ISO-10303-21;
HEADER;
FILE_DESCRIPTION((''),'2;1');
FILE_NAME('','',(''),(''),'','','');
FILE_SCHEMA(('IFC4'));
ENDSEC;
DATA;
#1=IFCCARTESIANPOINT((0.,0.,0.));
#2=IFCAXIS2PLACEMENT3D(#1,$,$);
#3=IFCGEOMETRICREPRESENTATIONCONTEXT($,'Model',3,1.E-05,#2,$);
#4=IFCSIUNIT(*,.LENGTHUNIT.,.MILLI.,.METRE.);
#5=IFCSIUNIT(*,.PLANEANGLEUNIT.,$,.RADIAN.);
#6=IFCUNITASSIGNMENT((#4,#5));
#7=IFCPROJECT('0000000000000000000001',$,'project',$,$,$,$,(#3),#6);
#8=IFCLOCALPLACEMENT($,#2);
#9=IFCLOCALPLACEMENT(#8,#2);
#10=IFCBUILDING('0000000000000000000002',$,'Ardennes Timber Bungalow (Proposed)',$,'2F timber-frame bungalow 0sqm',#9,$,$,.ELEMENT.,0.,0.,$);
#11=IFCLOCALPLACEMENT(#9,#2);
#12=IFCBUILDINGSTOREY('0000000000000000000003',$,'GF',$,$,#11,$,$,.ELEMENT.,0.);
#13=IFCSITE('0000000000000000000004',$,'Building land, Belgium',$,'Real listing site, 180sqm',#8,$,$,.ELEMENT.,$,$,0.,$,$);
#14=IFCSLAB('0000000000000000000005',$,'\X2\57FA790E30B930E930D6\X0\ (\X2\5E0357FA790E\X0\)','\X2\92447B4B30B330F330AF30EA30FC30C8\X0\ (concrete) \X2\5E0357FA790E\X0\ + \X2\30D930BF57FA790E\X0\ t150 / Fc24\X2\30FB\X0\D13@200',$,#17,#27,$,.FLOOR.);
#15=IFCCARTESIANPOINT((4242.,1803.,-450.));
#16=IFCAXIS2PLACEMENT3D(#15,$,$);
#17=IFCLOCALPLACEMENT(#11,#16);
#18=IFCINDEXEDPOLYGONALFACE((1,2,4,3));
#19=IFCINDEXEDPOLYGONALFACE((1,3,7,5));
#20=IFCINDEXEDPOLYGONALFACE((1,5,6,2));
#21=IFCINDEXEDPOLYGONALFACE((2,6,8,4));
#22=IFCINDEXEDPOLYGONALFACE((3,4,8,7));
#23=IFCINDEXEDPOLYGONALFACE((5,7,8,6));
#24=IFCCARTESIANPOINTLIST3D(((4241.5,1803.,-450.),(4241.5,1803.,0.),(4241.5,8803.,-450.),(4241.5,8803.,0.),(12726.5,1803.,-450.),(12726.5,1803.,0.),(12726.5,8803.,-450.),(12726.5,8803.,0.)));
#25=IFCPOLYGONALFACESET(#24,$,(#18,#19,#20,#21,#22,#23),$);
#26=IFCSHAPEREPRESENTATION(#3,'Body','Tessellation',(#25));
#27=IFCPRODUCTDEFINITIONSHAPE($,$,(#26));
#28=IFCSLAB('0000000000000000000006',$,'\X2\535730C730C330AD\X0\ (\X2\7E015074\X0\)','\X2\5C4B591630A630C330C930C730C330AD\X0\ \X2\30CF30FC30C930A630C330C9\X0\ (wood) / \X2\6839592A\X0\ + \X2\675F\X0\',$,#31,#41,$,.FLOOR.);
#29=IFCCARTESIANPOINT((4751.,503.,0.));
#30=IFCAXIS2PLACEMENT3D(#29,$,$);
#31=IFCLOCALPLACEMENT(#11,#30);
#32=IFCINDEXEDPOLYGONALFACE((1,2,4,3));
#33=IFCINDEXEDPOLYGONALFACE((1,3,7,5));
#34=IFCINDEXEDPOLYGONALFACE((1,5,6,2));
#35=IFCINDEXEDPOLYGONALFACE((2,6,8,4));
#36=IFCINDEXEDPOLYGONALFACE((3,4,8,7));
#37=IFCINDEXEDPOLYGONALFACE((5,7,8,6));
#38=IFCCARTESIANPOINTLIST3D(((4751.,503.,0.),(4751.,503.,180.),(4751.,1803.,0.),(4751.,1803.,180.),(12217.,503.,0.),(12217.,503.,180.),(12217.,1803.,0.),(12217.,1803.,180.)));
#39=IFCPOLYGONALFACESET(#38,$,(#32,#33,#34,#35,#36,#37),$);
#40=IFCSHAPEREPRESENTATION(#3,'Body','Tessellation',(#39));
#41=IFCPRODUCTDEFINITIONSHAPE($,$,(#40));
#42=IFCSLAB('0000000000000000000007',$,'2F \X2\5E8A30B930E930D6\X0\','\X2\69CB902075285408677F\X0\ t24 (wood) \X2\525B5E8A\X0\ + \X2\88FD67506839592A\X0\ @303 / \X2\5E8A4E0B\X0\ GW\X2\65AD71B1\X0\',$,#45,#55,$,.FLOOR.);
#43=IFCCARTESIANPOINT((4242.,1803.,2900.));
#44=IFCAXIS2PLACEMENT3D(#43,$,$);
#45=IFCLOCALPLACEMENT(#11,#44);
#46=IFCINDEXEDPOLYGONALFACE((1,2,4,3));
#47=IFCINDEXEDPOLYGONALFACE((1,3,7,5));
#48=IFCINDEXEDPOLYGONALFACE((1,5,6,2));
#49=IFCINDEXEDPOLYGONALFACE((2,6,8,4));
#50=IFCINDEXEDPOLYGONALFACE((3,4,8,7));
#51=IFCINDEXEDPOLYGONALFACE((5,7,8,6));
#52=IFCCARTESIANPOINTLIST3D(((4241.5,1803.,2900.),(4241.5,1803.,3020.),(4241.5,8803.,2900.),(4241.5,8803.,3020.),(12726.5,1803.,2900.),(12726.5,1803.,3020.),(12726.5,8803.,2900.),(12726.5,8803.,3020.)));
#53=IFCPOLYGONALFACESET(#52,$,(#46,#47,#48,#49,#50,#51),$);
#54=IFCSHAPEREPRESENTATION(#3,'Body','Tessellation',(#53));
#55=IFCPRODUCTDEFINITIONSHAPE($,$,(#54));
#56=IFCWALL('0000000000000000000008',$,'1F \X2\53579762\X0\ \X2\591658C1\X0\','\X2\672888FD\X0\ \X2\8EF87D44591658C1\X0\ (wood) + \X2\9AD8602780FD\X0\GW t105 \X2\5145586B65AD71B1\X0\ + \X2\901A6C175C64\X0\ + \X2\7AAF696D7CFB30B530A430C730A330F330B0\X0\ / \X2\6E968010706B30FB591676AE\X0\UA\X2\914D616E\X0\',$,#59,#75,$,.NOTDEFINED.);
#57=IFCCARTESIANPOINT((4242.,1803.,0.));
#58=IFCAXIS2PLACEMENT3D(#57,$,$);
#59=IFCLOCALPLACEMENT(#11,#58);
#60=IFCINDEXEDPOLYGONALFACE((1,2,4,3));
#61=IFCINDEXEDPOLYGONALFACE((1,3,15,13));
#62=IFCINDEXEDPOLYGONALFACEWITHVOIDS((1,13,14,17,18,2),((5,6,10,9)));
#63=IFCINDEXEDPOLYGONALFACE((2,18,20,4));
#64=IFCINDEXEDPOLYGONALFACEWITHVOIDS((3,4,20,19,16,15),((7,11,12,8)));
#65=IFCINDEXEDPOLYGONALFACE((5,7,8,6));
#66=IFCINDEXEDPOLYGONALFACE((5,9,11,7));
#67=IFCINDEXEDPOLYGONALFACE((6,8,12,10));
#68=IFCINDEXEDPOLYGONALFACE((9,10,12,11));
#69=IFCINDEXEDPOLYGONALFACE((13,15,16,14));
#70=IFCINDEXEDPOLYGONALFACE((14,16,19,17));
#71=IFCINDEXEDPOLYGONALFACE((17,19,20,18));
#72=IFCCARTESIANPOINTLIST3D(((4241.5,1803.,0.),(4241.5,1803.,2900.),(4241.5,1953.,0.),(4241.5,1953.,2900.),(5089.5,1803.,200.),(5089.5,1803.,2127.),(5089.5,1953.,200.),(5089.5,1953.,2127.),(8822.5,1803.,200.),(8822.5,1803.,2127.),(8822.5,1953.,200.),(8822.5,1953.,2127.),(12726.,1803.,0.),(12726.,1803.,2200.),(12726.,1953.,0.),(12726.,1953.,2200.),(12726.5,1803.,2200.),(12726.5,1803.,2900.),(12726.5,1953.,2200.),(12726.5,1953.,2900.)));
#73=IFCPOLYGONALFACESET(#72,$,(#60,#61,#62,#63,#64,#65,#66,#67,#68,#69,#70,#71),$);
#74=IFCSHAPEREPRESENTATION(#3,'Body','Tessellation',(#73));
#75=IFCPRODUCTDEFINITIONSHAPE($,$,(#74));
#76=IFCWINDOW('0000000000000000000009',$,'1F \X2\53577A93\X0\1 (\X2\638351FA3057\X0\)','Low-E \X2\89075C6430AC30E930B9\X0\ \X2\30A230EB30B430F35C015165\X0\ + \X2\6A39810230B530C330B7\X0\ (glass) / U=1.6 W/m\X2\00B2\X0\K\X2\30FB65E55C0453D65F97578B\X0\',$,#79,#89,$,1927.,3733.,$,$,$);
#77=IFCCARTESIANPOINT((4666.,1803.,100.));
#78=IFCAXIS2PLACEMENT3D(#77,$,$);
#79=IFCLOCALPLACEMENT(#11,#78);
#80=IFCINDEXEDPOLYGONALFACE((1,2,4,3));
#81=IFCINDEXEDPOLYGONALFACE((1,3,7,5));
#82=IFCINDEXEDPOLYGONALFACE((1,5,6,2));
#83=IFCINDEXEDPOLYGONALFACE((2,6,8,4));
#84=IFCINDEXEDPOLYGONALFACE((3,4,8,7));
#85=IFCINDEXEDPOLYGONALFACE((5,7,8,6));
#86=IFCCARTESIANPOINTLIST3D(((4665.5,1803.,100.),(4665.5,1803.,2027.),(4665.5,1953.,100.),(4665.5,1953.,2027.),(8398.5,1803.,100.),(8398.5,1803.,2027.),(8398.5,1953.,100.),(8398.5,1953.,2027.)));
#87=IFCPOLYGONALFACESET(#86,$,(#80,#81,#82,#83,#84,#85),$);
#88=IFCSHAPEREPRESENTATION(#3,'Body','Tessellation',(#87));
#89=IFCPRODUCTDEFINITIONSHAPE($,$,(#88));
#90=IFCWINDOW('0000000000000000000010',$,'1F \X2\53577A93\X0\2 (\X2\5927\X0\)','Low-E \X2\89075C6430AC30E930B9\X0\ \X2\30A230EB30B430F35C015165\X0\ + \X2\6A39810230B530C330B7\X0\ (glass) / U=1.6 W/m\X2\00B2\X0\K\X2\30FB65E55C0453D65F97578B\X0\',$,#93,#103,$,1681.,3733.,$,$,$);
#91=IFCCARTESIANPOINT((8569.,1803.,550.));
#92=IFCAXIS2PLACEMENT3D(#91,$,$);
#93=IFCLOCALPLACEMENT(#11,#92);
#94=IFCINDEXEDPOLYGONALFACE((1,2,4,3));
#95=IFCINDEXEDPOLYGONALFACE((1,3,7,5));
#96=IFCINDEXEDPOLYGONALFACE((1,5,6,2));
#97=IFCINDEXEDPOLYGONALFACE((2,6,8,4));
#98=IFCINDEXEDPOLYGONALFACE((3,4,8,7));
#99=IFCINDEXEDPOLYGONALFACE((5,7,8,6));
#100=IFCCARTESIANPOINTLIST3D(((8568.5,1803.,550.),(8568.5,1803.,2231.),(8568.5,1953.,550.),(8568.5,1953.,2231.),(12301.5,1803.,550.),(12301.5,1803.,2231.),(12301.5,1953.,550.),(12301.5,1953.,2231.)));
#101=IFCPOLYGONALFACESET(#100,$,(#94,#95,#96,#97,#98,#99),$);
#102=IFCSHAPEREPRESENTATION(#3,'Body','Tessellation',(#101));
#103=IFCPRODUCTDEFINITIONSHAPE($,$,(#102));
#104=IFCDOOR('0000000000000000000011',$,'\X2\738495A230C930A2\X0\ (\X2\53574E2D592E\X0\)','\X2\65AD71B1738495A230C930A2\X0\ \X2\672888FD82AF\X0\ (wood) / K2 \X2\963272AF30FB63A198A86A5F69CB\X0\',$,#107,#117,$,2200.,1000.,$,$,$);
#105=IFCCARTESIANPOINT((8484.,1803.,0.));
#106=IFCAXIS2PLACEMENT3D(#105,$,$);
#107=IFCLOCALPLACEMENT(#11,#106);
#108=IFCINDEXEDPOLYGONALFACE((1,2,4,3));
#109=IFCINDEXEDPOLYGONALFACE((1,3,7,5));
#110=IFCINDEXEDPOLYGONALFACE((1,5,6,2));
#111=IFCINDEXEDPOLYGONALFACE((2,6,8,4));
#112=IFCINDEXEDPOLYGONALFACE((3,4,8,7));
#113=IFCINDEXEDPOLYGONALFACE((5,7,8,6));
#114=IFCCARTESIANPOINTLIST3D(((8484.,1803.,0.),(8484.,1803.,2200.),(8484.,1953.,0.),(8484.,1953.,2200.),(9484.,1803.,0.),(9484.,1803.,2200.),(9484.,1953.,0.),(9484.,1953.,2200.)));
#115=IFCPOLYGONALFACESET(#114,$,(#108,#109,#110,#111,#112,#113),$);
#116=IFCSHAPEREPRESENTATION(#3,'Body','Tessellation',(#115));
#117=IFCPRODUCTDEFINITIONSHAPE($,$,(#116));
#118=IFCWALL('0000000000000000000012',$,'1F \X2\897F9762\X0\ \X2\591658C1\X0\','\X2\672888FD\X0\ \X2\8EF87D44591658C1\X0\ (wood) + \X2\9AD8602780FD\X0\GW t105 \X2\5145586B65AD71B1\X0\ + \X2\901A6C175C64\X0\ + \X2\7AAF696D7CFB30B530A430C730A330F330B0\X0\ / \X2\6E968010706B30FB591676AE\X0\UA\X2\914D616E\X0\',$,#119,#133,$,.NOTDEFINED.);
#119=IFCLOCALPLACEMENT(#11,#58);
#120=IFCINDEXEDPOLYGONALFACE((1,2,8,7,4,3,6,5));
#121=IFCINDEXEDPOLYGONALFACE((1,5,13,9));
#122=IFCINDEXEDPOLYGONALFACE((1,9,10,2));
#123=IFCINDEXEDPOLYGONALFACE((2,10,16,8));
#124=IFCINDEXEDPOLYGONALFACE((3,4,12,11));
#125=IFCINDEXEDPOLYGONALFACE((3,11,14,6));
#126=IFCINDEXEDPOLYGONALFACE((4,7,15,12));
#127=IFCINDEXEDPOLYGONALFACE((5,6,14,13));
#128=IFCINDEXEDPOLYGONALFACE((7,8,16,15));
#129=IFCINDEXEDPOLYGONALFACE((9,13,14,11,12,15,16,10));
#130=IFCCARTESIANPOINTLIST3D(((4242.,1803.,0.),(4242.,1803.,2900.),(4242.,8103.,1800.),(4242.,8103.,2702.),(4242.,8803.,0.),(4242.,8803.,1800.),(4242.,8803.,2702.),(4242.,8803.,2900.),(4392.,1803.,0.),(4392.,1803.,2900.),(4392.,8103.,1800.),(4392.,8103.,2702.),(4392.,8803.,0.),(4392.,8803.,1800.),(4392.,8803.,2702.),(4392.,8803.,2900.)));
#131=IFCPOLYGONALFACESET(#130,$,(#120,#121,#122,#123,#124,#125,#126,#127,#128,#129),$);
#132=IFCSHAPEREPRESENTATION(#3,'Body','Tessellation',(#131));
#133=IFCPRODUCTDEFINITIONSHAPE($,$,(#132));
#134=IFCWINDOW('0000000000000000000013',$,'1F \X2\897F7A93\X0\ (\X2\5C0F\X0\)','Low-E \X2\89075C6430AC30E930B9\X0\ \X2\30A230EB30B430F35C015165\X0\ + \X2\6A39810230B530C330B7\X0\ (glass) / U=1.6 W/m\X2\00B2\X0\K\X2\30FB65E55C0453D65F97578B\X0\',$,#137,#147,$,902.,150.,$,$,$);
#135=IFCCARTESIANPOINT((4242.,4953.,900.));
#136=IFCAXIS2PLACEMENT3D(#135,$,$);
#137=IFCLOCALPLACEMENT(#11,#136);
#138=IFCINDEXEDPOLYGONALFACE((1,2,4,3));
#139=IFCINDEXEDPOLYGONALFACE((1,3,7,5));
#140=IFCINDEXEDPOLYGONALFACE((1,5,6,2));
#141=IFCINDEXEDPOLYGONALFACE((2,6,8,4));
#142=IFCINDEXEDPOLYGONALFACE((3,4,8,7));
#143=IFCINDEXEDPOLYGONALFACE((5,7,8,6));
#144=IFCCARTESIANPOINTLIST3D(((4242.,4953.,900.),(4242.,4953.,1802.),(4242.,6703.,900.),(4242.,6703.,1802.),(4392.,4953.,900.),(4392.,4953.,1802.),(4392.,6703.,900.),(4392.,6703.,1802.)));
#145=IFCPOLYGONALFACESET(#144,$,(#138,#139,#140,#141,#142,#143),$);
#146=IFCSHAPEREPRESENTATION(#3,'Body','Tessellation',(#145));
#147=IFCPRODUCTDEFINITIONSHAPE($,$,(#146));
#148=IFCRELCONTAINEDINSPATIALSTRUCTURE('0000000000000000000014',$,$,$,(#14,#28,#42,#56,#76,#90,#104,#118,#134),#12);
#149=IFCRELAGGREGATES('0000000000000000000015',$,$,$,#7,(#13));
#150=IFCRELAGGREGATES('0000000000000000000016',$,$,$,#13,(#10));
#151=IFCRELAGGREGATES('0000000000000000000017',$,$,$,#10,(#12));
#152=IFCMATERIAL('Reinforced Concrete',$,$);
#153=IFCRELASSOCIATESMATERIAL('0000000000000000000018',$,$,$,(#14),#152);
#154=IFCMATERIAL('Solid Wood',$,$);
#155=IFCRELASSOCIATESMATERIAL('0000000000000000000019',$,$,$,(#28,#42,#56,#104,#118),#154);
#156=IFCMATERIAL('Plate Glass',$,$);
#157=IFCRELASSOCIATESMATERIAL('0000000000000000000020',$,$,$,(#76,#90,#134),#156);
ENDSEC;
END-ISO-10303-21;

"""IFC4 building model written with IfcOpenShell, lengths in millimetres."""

from ifc_helpers import new_model, si_unit, frame, frame_2d, origin, place, context, project, spatial, rectangle, extrude, material, element, fill, save


model = new_model("IFC4")

# Units and contexts
model_context = context("Model", 3, precision=1e-05, world=origin())
ifc_project = project(units=[si_unit("LENGTHUNIT", "METRE", prefix="MILLI"), si_unit("PLANEANGLEUNIT", "RADIAN")], contexts=[model_context])

# Site, building, storey
site_placement = place(None, origin())
site = spatial("IfcSite", under=ifc_project, at=site_placement, Name="Building land, Belgium", ObjectType="Real listing site, 180sqm", CompositionType="ELEMENT", RefElevation=0.0)
building_placement = place(site_placement, origin())
building = spatial("IfcBuilding", under=site, at=building_placement, Name="Ardennes Timber Bungalow (Proposed)", ObjectType="2F timber-frame bungalow 0sqm", CompositionType="ELEMENT", ElevationOfRefHeight=0.0, ElevationOfTerrain=0.0)
storey_placement = place(building_placement, origin())
storey = spatial("IfcBuildingStorey", under=building, at=storey_placement, Name="GF", CompositionType="ELEMENT", Elevation=0.0)

# Slabs
ifc_material_1 = material(Name="Reinforced Concrete")
slab_1_placement = place(storey_placement, frame((4242.0, 1803.0, -450.0)))
element("IfcSlab", 1, at=slab_1_placement, inside=storey, material=ifc_material_1, Name="基礎スラブ (布基礎)", Description="鉄筋コンクリート (concrete) 布基礎 + ベタ基礎 t150 / Fc24・D13@200", PredefinedType="FLOOR", context=model_context, shape_type="SweptSolid", body=[
    extrude(rectangle(XDim=8485.0, YDim=7000.0, at=frame_2d((4242.0, 3500.0))), frame((4242.0, 1803.0, -450.0)), (0.0, 0.0, 1.0), 450.0),
])
ifc_material_2 = material(Name="Solid Wood")
slab_2_placement = place(storey_placement, frame((4751.0, 503.0, 0.0)))
element("IfcSlab", 2, at=slab_2_placement, inside=storey, material=ifc_material_2, Name="南デッキ (縁側)", Description="屋外ウッドデッキ ハードウッド (wood) / 根太 + 束", PredefinedType="FLOOR", context=model_context, shape_type="SweptSolid", body=[
    extrude(rectangle(XDim=7466.0, YDim=1300.0, at=frame_2d((3733.0, 650.0))), frame((4751.0, 503.0, 0.0)), (0.0, 0.0, 1.0), 180.0),
])
slab_3_placement = place(storey_placement, frame((4242.0, 1803.0, 2900.0)))
element("IfcSlab", 3, at=slab_3_placement, inside=storey, material=ifc_material_2, Name="2F 床スラブ", Description="構造用合板 t24 (wood) 剛床 + 製材根太 @303 / 床下 GW断熱", PredefinedType="FLOOR", context=model_context, shape_type="SweptSolid", body=[
    extrude(rectangle(XDim=8485.0, YDim=7000.0, at=frame_2d((4242.0, 3500.0))), frame((4242.0, 1803.0, 2900.0)), (0.0, 0.0, 1.0), 120.0),
])

# Wall, openings, windows, door
wall_1_placement = place(storey_placement, frame((4242.0, 1803.0, 0.0)))
wall_1 = element("IfcWall", 4, at=wall_1_placement, inside=storey, material=ifc_material_2, Name="1F 南面 外壁", Description="木製 軸組外壁 (wood) + 高性能GW t105 充填断熱 + 通気層 + 窯業系サイディング / 準耐火・外皮UA配慮", PredefinedType="NOTDEFINED", context=model_context, shape_type="SweptSolid", body=[
    extrude(rectangle(XDim=8485.0, YDim=150.0, at=frame_2d((4242.0, 75.0))), frame((4242.0, 1803.0, 0.0)), (0.0, 0.0, 1.0), 2900.0),
])
opening_1_placement = place(storey_placement, frame((4666.0, 1803.0, 100.0)))
opening_1 = element("IfcOpeningElement", 5, at=opening_1_placement, cuts=wall_1, PredefinedType="NOTDEFINED", context=model_context, shape_type="SweptSolid", body=[
    extrude(rectangle(XDim=3733.0, YDim=150.0, at=frame_2d((1866.0, 75.0))), frame((4666.0, 1803.0, 100.0)), (0.0, 0.0, 1.0), 1927.0),
])
opening_2_placement = place(storey_placement, frame((8569.0, 1803.0, 550.0)))
opening_2 = element("IfcOpeningElement", 6, at=opening_2_placement, cuts=wall_1, PredefinedType="NOTDEFINED", context=model_context, shape_type="SweptSolid", body=[
    extrude(rectangle(XDim=3733.0, YDim=150.0, at=frame_2d((1866.0, 75.0))), frame((8569.0, 1803.0, 550.0)), (0.0, 0.0, 1.0), 1681.0),
])
opening_3_placement = place(storey_placement, frame((8484.0, 1803.0, 0.0)))
opening_3 = element("IfcOpeningElement", 7, at=opening_3_placement, cuts=wall_1, PredefinedType="NOTDEFINED", context=model_context, shape_type="SweptSolid", body=[
    extrude(rectangle(XDim=1000.0, YDim=150.0, at=frame_2d((500.0, 75.0))), frame((8484.0, 1803.0, 0.0)), (0.0, 0.0, 1.0), 2200.0),
])
ifc_material_3 = material(Name="Plate Glass")
window_1_placement = place(storey_placement, frame((4666.0, 1803.0, 100.0)))
window_1 = element("IfcWindow", 8, at=window_1_placement, inside=storey, material=ifc_material_3, Name="1F 南窓1 (掃出し)", Description="Low-E 複層ガラス アルゴン封入 + 樹脂サッシ (glass) / U=1.6 W/m²K・日射取得型", OverallHeight=1927.0, OverallWidth=3733.0, context=model_context, shape_type="SweptSolid", body=[
    extrude(rectangle(XDim=3733.0, YDim=150.0, at=frame_2d((1866.0, 75.0))), frame((4666.0, 1803.0, 100.0)), (0.0, 0.0, 1.0), 1927.0),
])
fill(opening_1, window_1)
window_2_placement = place(storey_placement, frame((8569.0, 1803.0, 550.0)))
window_2 = element("IfcWindow", 9, at=window_2_placement, inside=storey, material=ifc_material_3, Name="1F 南窓2 (大)", Description="Low-E 複層ガラス アルゴン封入 + 樹脂サッシ (glass) / U=1.6 W/m²K・日射取得型", OverallHeight=1681.0, OverallWidth=3733.0, context=model_context, shape_type="SweptSolid", body=[
    extrude(rectangle(XDim=3733.0, YDim=150.0, at=frame_2d((1866.0, 75.0))), frame((8569.0, 1803.0, 550.0)), (0.0, 0.0, 1.0), 1681.0),
])
fill(opening_2, window_2)
door_placement = place(storey_placement, frame((8484.0, 1803.0, 0.0)))
door = element("IfcDoor", 10, at=door_placement, inside=storey, material=ifc_material_2, Name="玄関ドア (南中央)", Description="断熱玄関ドア 木製芯 (wood) / K2 防犯・採風機構", OverallHeight=2200.0, OverallWidth=1000.0, context=model_context, shape_type="SweptSolid", body=[
    extrude(rectangle(XDim=1000.0, YDim=150.0, at=frame_2d((500.0, 75.0))), frame((8484.0, 1803.0, 0.0)), (0.0, 0.0, 1.0), 2200.0),
])
fill(opening_3, door)

# Wall, opening, window
wall_2_placement = place(storey_placement, frame((4242.0, 1803.0, 0.0)))
wall_2 = element("IfcWall", 11, at=wall_2_placement, inside=storey, material=ifc_material_2, Name="1F 西面 外壁", Description="木製 軸組外壁 (wood) + 高性能GW t105 充填断熱 + 通気層 + 窯業系サイディング / 準耐火・外皮UA配慮", PredefinedType="NOTDEFINED", context=model_context, shape_type="SweptSolid", body=[
    extrude(rectangle(XDim=150.0, YDim=7000.0, at=frame_2d((75.0, 3500.0))), frame((4242.0, 1803.0, 0.0)), (0.0, 0.0, 1.0), 2900.0),
])
opening_4_placement = place(storey_placement, frame((4242.0, 4953.0, 900.0)))
opening_4 = element("IfcOpeningElement", 12, at=opening_4_placement, cuts=wall_2, PredefinedType="NOTDEFINED", context=model_context, shape_type="SweptSolid", body=[
    extrude(rectangle(XDim=150.0, YDim=1750.0, at=frame_2d((75.0, 875.0))), frame((4242.0, 4953.0, 900.0)), (0.0, 0.0, 1.0), 902.0),
])
window_3_placement = place(storey_placement, frame((4242.0, 4953.0, 900.0)))
window_3 = element("IfcWindow", 13, at=window_3_placement, inside=storey, material=ifc_material_3, Name="1F 西窓 (小)", Description="Low-E 複層ガラス アルゴン封入 + 樹脂サッシ (glass) / U=1.6 W/m²K・日射取得型", OverallHeight=902.0, OverallWidth=150.0, context=model_context, shape_type="SweptSolid", body=[
    extrude(rectangle(XDim=150.0, YDim=1750.0, at=frame_2d((75.0, 875.0))), frame((4242.0, 4953.0, 900.0)), (0.0, 0.0, 1.0), 902.0),
])
fill(opening_4, window_3)

save(model, "model.ifc")
